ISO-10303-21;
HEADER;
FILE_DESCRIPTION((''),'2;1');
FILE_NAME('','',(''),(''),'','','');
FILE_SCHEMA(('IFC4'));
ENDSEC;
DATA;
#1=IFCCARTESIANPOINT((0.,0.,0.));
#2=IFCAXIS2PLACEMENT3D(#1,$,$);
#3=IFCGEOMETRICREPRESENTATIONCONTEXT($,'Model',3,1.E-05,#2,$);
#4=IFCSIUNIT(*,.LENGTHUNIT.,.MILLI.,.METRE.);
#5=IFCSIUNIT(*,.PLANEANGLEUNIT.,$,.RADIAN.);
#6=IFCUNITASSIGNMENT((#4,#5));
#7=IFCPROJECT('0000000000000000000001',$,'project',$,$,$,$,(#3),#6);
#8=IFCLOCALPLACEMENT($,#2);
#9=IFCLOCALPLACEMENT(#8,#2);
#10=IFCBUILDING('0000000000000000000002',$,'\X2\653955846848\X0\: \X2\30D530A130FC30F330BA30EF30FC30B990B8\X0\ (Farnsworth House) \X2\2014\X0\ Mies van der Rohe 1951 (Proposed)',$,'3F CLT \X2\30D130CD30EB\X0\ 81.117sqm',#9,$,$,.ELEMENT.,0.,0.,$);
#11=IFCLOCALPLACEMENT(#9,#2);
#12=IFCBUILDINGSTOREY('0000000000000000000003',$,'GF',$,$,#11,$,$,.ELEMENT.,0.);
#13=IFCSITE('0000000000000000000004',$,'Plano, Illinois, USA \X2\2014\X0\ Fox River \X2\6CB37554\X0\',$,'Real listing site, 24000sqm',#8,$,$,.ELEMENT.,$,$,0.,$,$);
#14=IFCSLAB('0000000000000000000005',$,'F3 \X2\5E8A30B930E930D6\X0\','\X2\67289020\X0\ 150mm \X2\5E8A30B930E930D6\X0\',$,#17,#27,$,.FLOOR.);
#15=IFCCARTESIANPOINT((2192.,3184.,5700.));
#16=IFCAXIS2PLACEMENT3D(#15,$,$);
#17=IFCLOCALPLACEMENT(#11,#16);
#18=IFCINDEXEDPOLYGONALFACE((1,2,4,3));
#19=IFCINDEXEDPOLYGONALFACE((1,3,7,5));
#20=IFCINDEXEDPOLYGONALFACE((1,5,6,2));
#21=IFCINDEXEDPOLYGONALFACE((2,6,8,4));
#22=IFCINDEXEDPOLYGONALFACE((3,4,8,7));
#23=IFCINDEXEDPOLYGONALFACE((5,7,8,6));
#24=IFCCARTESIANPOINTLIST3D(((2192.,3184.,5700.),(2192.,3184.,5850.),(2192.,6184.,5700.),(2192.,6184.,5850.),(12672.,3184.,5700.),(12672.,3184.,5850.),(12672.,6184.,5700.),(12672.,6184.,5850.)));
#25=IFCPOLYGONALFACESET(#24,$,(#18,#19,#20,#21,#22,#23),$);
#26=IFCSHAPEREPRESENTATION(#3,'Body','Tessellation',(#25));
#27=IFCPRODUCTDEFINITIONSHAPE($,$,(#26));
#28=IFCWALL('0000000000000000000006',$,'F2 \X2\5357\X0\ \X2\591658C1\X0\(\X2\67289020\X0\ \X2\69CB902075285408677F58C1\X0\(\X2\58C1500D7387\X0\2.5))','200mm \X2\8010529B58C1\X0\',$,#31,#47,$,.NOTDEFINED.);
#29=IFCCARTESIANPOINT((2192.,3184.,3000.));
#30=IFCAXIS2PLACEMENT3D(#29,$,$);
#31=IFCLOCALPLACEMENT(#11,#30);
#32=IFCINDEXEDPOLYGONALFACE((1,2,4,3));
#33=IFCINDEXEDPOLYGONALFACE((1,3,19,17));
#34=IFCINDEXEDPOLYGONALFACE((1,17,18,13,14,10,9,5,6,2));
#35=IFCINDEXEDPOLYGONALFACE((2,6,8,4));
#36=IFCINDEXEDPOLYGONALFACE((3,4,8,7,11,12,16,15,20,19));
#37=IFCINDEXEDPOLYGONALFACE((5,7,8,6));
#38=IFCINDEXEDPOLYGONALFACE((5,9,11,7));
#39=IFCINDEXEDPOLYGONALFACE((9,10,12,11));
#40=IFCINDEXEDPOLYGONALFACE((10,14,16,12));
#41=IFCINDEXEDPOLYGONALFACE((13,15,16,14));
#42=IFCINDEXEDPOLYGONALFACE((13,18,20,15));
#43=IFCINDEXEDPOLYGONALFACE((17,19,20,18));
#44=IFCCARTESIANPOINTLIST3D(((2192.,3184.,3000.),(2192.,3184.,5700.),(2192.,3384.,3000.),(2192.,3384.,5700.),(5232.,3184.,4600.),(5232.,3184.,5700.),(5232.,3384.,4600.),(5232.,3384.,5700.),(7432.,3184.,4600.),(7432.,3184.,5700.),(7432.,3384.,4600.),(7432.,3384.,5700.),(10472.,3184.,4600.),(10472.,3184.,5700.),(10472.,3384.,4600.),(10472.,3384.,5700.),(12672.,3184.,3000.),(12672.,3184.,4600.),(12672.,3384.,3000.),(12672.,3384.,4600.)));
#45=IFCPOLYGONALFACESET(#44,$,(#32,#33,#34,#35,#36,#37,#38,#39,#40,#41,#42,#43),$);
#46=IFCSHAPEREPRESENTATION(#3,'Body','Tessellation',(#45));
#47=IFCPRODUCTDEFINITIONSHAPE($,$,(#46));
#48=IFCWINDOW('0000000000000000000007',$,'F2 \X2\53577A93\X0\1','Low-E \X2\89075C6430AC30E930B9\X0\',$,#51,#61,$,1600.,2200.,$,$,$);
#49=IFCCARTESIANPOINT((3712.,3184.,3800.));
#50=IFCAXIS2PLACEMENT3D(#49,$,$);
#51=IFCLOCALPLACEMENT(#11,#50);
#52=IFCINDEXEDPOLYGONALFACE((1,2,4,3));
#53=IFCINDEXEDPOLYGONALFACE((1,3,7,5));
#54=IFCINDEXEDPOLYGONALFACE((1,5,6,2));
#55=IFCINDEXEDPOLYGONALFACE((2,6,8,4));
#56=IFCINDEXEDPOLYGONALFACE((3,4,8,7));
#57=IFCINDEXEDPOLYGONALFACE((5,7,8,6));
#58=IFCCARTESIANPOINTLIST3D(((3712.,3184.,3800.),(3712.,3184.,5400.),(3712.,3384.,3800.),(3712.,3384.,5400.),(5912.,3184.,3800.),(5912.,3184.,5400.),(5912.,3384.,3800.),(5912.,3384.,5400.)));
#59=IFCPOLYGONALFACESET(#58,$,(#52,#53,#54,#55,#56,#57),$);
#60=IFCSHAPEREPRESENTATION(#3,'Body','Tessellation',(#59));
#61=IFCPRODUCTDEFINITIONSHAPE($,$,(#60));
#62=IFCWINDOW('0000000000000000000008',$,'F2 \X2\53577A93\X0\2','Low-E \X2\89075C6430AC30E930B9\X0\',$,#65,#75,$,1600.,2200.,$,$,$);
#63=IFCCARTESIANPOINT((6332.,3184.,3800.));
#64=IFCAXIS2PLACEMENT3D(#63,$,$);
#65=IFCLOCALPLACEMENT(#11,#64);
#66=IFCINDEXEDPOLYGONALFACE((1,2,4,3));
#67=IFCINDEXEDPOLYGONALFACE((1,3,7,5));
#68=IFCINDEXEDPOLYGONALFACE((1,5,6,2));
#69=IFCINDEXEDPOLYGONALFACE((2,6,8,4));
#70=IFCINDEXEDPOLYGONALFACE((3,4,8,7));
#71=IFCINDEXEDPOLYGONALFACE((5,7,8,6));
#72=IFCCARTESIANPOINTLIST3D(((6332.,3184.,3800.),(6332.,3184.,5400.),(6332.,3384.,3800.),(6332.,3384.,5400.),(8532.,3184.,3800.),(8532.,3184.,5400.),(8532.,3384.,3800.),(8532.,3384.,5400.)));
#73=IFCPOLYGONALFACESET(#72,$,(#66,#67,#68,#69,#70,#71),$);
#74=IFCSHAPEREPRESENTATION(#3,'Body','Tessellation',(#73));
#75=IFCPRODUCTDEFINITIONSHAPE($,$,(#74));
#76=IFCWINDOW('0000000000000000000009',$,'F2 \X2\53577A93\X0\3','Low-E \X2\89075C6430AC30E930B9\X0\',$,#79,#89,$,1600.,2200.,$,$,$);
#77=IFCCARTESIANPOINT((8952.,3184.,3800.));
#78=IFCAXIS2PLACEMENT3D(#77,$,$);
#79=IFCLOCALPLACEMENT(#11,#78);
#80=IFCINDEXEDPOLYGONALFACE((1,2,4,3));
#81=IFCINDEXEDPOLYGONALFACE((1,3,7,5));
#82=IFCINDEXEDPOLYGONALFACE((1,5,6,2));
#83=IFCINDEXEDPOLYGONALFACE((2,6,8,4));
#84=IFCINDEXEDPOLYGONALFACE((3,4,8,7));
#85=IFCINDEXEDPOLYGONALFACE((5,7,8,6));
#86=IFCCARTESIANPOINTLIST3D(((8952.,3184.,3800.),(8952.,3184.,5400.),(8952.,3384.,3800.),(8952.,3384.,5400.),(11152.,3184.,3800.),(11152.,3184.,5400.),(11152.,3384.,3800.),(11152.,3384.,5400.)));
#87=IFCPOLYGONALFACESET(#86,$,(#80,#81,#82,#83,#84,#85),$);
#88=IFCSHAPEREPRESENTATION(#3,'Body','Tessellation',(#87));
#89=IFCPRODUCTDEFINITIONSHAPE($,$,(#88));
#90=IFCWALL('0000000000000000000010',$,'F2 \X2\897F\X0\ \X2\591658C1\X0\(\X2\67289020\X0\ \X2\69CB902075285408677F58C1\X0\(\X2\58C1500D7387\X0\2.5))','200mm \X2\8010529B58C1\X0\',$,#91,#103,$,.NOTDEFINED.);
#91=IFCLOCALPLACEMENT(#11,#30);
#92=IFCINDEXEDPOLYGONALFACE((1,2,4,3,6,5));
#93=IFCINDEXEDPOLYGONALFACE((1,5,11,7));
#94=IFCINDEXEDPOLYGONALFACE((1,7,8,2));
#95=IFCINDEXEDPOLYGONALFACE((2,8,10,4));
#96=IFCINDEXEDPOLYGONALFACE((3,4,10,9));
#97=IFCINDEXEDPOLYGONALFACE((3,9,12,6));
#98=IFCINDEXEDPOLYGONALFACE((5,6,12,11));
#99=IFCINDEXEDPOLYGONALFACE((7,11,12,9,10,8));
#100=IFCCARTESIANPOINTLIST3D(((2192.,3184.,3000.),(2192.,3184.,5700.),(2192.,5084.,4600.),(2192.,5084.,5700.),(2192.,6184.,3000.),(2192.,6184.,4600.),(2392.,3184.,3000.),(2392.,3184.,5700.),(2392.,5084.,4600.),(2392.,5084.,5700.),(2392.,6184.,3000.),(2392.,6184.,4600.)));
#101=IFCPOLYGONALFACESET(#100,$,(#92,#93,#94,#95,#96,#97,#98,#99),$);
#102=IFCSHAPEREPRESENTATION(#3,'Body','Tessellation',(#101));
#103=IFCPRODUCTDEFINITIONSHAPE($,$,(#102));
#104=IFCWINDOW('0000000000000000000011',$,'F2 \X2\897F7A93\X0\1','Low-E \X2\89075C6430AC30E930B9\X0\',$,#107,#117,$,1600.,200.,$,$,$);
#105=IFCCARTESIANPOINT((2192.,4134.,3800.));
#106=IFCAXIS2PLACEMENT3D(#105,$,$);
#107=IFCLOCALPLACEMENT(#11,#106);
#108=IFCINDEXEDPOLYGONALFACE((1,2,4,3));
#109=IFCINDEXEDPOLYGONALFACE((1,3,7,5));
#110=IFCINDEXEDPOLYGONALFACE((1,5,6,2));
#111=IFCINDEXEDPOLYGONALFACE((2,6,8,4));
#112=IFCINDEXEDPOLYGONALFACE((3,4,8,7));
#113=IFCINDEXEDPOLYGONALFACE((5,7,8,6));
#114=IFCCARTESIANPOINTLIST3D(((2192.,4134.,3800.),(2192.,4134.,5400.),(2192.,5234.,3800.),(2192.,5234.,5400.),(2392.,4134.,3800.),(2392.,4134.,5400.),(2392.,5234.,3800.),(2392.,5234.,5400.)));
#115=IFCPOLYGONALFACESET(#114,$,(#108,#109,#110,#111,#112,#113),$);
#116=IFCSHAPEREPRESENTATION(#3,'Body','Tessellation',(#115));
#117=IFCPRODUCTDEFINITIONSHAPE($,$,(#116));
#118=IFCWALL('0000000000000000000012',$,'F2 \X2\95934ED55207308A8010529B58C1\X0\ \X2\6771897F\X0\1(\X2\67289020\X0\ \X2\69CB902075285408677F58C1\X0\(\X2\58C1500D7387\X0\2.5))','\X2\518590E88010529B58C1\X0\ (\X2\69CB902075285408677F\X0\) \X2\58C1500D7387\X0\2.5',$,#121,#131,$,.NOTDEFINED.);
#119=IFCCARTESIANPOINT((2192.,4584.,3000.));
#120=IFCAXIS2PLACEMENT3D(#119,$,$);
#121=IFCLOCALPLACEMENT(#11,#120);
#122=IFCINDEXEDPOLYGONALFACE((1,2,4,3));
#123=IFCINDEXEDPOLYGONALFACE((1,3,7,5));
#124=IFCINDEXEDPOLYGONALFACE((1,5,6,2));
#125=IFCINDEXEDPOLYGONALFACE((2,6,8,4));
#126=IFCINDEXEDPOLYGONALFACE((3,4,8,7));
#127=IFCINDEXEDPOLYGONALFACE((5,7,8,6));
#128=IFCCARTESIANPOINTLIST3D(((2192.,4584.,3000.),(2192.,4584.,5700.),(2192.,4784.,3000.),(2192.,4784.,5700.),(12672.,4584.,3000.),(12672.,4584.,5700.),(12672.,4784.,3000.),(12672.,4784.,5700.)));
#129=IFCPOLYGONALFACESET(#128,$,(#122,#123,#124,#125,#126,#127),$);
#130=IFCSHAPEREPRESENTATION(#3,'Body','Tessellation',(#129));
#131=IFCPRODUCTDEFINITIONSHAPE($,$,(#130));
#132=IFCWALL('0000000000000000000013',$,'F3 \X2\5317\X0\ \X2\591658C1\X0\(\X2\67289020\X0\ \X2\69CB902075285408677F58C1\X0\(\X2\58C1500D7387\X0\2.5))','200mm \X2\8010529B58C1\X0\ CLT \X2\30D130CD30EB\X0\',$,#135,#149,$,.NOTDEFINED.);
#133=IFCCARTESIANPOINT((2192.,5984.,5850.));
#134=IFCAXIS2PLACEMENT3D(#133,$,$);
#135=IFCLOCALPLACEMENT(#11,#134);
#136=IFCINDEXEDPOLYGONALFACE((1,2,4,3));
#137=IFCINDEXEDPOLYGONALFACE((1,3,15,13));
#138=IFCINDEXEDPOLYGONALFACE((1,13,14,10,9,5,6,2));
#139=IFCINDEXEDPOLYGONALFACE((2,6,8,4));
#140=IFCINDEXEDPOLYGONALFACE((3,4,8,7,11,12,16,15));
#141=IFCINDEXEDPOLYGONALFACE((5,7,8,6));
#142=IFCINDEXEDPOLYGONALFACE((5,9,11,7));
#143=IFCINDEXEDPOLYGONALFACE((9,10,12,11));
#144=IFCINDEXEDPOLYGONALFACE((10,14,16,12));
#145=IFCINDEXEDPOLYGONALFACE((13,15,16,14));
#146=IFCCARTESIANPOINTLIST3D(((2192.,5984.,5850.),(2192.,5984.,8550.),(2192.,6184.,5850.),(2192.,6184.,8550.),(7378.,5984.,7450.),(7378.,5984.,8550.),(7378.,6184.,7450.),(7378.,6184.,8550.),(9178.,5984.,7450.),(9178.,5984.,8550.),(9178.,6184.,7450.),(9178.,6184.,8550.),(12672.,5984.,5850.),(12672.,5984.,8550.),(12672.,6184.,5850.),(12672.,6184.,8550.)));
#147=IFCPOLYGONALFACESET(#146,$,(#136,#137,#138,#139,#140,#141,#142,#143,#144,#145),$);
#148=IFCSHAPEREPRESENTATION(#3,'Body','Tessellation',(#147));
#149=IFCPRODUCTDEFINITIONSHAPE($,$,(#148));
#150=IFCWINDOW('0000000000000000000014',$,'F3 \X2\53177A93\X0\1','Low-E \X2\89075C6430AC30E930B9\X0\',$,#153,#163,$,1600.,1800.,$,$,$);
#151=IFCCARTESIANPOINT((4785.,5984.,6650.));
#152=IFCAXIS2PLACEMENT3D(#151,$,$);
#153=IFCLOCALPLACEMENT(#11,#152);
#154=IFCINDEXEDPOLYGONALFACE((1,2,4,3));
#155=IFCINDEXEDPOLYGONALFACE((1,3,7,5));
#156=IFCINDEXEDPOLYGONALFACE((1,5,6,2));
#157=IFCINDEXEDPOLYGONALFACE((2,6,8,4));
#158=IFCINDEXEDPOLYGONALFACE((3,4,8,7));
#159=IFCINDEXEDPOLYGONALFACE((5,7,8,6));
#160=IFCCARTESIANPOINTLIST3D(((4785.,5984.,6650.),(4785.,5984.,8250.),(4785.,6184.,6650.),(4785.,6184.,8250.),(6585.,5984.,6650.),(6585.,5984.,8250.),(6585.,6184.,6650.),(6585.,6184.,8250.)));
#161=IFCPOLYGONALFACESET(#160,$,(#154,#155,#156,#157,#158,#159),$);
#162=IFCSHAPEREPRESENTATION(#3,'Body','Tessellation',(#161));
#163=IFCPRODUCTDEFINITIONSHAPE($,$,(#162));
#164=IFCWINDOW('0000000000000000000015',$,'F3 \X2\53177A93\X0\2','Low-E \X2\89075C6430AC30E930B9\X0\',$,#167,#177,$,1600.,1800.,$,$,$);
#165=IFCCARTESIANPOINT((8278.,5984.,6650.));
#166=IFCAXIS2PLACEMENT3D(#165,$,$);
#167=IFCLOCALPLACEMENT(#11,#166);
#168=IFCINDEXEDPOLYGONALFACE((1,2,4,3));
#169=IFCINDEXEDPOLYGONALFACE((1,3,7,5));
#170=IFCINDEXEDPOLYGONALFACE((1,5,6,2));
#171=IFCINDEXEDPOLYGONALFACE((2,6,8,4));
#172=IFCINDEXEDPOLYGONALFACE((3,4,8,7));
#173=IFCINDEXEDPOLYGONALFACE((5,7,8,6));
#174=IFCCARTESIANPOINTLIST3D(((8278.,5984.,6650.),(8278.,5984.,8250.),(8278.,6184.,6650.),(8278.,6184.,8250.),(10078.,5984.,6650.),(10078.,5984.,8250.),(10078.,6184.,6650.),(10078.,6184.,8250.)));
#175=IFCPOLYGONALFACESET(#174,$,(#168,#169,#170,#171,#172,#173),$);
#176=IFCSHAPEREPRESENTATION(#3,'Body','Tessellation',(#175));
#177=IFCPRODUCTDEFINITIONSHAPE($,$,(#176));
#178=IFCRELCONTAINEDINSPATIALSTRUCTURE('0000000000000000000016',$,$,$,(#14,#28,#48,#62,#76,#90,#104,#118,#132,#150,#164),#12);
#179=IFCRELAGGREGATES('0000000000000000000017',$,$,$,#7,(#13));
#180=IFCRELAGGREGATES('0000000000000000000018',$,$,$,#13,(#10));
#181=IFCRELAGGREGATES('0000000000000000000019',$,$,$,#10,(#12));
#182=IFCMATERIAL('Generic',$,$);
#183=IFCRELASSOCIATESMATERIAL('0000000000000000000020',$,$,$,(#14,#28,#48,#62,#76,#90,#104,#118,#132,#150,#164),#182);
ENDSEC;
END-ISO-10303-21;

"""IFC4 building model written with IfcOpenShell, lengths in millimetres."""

from ifc_helpers import new_model, si_unit, frame, frame_2d, origin, place, context, project, spatial, rectangle, extrude, material, element, fill, save


model = new_model("IFC4")

# Units and contexts
model_context = context("Model", 3, precision=1e-05, world=origin())
ifc_project = project(units=[si_unit("LENGTHUNIT", "METRE", prefix="MILLI"), si_unit("PLANEANGLEUNIT", "RADIAN")], contexts=[model_context])

# Site, building, storey
site_placement = place(None, origin())
site = spatial("IfcSite", under=ifc_project, at=site_placement, Name="Plano, Illinois, USA — Fox River 河畔", ObjectType="Real listing site, 24000sqm", CompositionType="ELEMENT", RefElevation=0.0)
building_placement = place(site_placement, origin())
building = spatial("IfcBuilding", under=site, at=building_placement, Name="改善案: ファーンズワース邸 (Farnsworth House) — Mies van der Rohe 1951 (Proposed)", ObjectType="3F CLT パネル 81.117sqm", CompositionType="ELEMENT", ElevationOfRefHeight=0.0, ElevationOfTerrain=0.0)
storey_placement = place(building_placement, origin())
storey = spatial("IfcBuildingStorey", under=building, at=storey_placement, Name="GF", CompositionType="ELEMENT", Elevation=0.0)

# Slab
ifc_material = material(Name="Generic")
slab_placement = place(storey_placement, frame((2192.0, 3184.0, 5700.0)))
element("IfcSlab", 1, at=slab_placement, inside=storey, material=ifc_material, Name="F3 床スラブ", Description="木造 150mm 床スラブ", PredefinedType="FLOOR", context=model_context, shape_type="SweptSolid", body=[
    extrude(rectangle(XDim=10480.0, YDim=3000.0, at=frame_2d((5240.0, 1500.0))), frame((2192.0, 3184.0, 5700.0)), (0.0, 0.0, 1.0), 150.0),
])

# Wall, openings, windows
wall_1_placement = place(storey_placement, frame((2192.0, 3184.0, 3000.0)))
wall_1 = element("IfcWall", 2, at=wall_1_placement, inside=storey, material=ifc_material, Name="F2 南 外壁(木造 構造用合板壁(壁倍率2.5))", Description="200mm 耐力壁", PredefinedType="NOTDEFINED", context=model_context, shape_type="SweptSolid", body=[
    extrude(rectangle(XDim=10480.0, YDim=200.0, at=frame_2d((5240.0, 100.0))), frame((2192.0, 3184.0, 3000.0)), (0.0, 0.0, 1.0), 2700.0),
])
opening_1_placement = place(storey_placement, frame((3712.0, 3184.0, 3800.0)))
opening_1 = element("IfcOpeningElement", 3, at=opening_1_placement, cuts=wall_1, PredefinedType="NOTDEFINED", context=model_context, shape_type="SweptSolid", body=[
    extrude(rectangle(XDim=2200.0, YDim=200.0, at=frame_2d((1100.0, 100.0))), frame((3712.0, 3184.0, 3800.0)), (0.0, 0.0, 1.0), 1600.0),
])
opening_2_placement = place(storey_placement, frame((6332.0, 3184.0, 3800.0)))
opening_2 = element("IfcOpeningElement", 4, at=opening_2_placement, cuts=wall_1, PredefinedType="NOTDEFINED", context=model_context, shape_type="SweptSolid", body=[
    extrude(rectangle(XDim=2200.0, YDim=200.0, at=frame_2d((1100.0, 100.0))), frame((6332.0, 3184.0, 3800.0)), (0.0, 0.0, 1.0), 1600.0),
])
opening_3_placement = place(storey_placement, frame((8952.0, 3184.0, 3800.0)))
opening_3 = element("IfcOpeningElement", 5, at=opening_3_placement, cuts=wall_1, PredefinedType="NOTDEFINED", context=model_context, shape_type="SweptSolid", body=[
    extrude(rectangle(XDim=2200.0, YDim=200.0, at=frame_2d((1100.0, 100.0))), frame((8952.0, 3184.0, 3800.0)), (0.0, 0.0, 1.0), 1600.0),
])
window_1_placement = place(storey_placement, frame((3712.0, 3184.0, 3800.0)))
window_1 = element("IfcWindow", 6, at=window_1_placement, inside=storey, material=ifc_material, Name="F2 南窓1", Description="Low-E 複層ガラス", OverallHeight=1600.0, OverallWidth=2200.0, context=model_context, shape_type="SweptSolid", body=[
    extrude(rectangle(XDim=2200.0, YDim=200.0, at=frame_2d((1100.0, 100.0))), frame((3712.0, 3184.0, 3800.0)), (0.0, 0.0, 1.0), 1600.0),
])
fill(opening_1, window_1)
window_2_placement = place(storey_placement, frame((6332.0, 3184.0, 3800.0)))
window_2 = element("IfcWindow", 7, at=window_2_placement, inside=storey, material=ifc_material, Name="F2 南窓2", Description="Low-E 複層ガラス", OverallHeight=1600.0, OverallWidth=2200.0, context=model_context, shape_type="SweptSolid", body=[
    extrude(rectangle(XDim=2200.0, YDim=200.0, at=frame_2d((1100.0, 100.0))), frame((6332.0, 3184.0, 3800.0)), (0.0, 0.0, 1.0), 1600.0),
])
fill(opening_2, window_2)
window_3_placement = place(storey_placement, frame((8952.0, 3184.0, 3800.0)))
window_3 = element("IfcWindow", 8, at=window_3_placement, inside=storey, material=ifc_material, Name="F2 南窓3", Description="Low-E 複層ガラス", OverallHeight=1600.0, OverallWidth=2200.0, context=model_context, shape_type="SweptSolid", body=[
    extrude(rectangle(XDim=2200.0, YDim=200.0, at=frame_2d((1100.0, 100.0))), frame((8952.0, 3184.0, 3800.0)), (0.0, 0.0, 1.0), 1600.0),
])
fill(opening_3, window_3)

# Wall, opening, window
wall_2_placement = place(storey_placement, frame((2192.0, 3184.0, 3000.0)))
wall_2 = element("IfcWall", 9, at=wall_2_placement, inside=storey, material=ifc_material, Name="F2 西 外壁(木造 構造用合板壁(壁倍率2.5))", Description="200mm 耐力壁", PredefinedType="NOTDEFINED", context=model_context, shape_type="SweptSolid", body=[
    extrude(rectangle(XDim=200.0, YDim=3000.0, at=frame_2d((100.0, 1500.0))), frame((2192.0, 3184.0, 3000.0)), (0.0, 0.0, 1.0), 2700.0),
])
opening_4_placement = place(storey_placement, frame((2192.0, 4134.0, 3800.0)))
opening_4 = element("IfcOpeningElement", 10, at=opening_4_placement, cuts=wall_2, PredefinedType="NOTDEFINED", context=model_context, shape_type="SweptSolid", body=[
    extrude(rectangle(XDim=200.0, YDim=1100.0, at=frame_2d((100.0, 550.0))), frame((2192.0, 4134.0, 3800.0)), (0.0, 0.0, 1.0), 1600.0),
])
window_4_placement = place(storey_placement, frame((2192.0, 4134.0, 3800.0)))
window_4 = element("IfcWindow", 11, at=window_4_placement, inside=storey, material=ifc_material, Name="F2 西窓1", Description="Low-E 複層ガラス", OverallHeight=1600.0, OverallWidth=200.0, context=model_context, shape_type="SweptSolid", body=[
    extrude(rectangle(XDim=200.0, YDim=1100.0, at=frame_2d((100.0, 550.0))), frame((2192.0, 4134.0, 3800.0)), (0.0, 0.0, 1.0), 1600.0),
])
fill(opening_4, window_4)

# Wall
wall_3_placement = place(storey_placement, frame((2192.0, 4584.0, 3000.0)))
element("IfcWall", 12, at=wall_3_placement, inside=storey, material=ifc_material, Name="F2 間仕切り耐力壁 東西1(木造 構造用合板壁(壁倍率2.5))", Description="内部耐力壁 (構造用合板) 壁倍率2.5", PredefinedType="NOTDEFINED", context=model_context, shape_type="SweptSolid", body=[
    extrude(rectangle(XDim=10480.0, YDim=200.0, at=frame_2d((5240.0, 100.0))), frame((2192.0, 4584.0, 3000.0)), (0.0, 0.0, 1.0), 2700.0),
])

# Wall, openings, windows
wall_4_placement = place(storey_placement, frame((2192.0, 5984.0, 5850.0)))
wall_4 = element("IfcWall", 13, at=wall_4_placement, inside=storey, material=ifc_material, Name="F3 北 外壁(木造 構造用合板壁(壁倍率2.5))", Description="200mm 耐力壁 CLT パネル", PredefinedType="NOTDEFINED", context=model_context, shape_type="SweptSolid", body=[
    extrude(rectangle(XDim=10480.0, YDim=200.0, at=frame_2d((5240.0, 100.0))), frame((2192.0, 5984.0, 5850.0)), (0.0, 0.0, 1.0), 2700.0),
])
opening_5_placement = place(storey_placement, frame((4785.0, 5984.0, 6650.0)))
opening_5 = element("IfcOpeningElement", 14, at=opening_5_placement, cuts=wall_4, PredefinedType="NOTDEFINED", context=model_context, shape_type="SweptSolid", body=[
    extrude(rectangle(XDim=1800.0, YDim=200.0, at=frame_2d((900.0, 100.0))), frame((4785.0, 5984.0, 6650.0)), (0.0, 0.0, 1.0), 1600.0),
])
opening_6_placement = place(storey_placement, frame((8278.0, 5984.0, 6650.0)))
opening_6 = element("IfcOpeningElement", 15, at=opening_6_placement, cuts=wall_4, PredefinedType="NOTDEFINED", context=model_context, shape_type="SweptSolid", body=[
    extrude(rectangle(XDim=1800.0, YDim=200.0, at=frame_2d((900.0, 100.0))), frame((8278.0, 5984.0, 6650.0)), (0.0, 0.0, 1.0), 1600.0),
])
window_5_placement = place(storey_placement, frame((4785.0, 5984.0, 6650.0)))
window_5 = element("IfcWindow", 16, at=window_5_placement, inside=storey, material=ifc_material, Name="F3 北窓1", Description="Low-E 複層ガラス", OverallHeight=1600.0, OverallWidth=1800.0, context=model_context, shape_type="SweptSolid", body=[
    extrude(rectangle(XDim=1800.0, YDim=200.0, at=frame_2d((900.0, 100.0))), frame((4785.0, 5984.0, 6650.0)), (0.0, 0.0, 1.0), 1600.0),
])
fill(opening_5, window_5)
window_6_placement = place(storey_placement, frame((8278.0, 5984.0, 6650.0)))
window_6 = element("IfcWindow", 17, at=window_6_placement, inside=storey, material=ifc_material, Name="F3 北窓2", Description="Low-E 複層ガラス", OverallHeight=1600.0, OverallWidth=1800.0, context=model_context, shape_type="SweptSolid", body=[
    extrude(rectangle(XDim=1800.0, YDim=200.0, at=frame_2d((900.0, 100.0))), frame((8278.0, 5984.0, 6650.0)), (0.0, 0.0, 1.0), 1600.0),
])
fill(opening_6, window_6)

save(model, "model.ifc")
